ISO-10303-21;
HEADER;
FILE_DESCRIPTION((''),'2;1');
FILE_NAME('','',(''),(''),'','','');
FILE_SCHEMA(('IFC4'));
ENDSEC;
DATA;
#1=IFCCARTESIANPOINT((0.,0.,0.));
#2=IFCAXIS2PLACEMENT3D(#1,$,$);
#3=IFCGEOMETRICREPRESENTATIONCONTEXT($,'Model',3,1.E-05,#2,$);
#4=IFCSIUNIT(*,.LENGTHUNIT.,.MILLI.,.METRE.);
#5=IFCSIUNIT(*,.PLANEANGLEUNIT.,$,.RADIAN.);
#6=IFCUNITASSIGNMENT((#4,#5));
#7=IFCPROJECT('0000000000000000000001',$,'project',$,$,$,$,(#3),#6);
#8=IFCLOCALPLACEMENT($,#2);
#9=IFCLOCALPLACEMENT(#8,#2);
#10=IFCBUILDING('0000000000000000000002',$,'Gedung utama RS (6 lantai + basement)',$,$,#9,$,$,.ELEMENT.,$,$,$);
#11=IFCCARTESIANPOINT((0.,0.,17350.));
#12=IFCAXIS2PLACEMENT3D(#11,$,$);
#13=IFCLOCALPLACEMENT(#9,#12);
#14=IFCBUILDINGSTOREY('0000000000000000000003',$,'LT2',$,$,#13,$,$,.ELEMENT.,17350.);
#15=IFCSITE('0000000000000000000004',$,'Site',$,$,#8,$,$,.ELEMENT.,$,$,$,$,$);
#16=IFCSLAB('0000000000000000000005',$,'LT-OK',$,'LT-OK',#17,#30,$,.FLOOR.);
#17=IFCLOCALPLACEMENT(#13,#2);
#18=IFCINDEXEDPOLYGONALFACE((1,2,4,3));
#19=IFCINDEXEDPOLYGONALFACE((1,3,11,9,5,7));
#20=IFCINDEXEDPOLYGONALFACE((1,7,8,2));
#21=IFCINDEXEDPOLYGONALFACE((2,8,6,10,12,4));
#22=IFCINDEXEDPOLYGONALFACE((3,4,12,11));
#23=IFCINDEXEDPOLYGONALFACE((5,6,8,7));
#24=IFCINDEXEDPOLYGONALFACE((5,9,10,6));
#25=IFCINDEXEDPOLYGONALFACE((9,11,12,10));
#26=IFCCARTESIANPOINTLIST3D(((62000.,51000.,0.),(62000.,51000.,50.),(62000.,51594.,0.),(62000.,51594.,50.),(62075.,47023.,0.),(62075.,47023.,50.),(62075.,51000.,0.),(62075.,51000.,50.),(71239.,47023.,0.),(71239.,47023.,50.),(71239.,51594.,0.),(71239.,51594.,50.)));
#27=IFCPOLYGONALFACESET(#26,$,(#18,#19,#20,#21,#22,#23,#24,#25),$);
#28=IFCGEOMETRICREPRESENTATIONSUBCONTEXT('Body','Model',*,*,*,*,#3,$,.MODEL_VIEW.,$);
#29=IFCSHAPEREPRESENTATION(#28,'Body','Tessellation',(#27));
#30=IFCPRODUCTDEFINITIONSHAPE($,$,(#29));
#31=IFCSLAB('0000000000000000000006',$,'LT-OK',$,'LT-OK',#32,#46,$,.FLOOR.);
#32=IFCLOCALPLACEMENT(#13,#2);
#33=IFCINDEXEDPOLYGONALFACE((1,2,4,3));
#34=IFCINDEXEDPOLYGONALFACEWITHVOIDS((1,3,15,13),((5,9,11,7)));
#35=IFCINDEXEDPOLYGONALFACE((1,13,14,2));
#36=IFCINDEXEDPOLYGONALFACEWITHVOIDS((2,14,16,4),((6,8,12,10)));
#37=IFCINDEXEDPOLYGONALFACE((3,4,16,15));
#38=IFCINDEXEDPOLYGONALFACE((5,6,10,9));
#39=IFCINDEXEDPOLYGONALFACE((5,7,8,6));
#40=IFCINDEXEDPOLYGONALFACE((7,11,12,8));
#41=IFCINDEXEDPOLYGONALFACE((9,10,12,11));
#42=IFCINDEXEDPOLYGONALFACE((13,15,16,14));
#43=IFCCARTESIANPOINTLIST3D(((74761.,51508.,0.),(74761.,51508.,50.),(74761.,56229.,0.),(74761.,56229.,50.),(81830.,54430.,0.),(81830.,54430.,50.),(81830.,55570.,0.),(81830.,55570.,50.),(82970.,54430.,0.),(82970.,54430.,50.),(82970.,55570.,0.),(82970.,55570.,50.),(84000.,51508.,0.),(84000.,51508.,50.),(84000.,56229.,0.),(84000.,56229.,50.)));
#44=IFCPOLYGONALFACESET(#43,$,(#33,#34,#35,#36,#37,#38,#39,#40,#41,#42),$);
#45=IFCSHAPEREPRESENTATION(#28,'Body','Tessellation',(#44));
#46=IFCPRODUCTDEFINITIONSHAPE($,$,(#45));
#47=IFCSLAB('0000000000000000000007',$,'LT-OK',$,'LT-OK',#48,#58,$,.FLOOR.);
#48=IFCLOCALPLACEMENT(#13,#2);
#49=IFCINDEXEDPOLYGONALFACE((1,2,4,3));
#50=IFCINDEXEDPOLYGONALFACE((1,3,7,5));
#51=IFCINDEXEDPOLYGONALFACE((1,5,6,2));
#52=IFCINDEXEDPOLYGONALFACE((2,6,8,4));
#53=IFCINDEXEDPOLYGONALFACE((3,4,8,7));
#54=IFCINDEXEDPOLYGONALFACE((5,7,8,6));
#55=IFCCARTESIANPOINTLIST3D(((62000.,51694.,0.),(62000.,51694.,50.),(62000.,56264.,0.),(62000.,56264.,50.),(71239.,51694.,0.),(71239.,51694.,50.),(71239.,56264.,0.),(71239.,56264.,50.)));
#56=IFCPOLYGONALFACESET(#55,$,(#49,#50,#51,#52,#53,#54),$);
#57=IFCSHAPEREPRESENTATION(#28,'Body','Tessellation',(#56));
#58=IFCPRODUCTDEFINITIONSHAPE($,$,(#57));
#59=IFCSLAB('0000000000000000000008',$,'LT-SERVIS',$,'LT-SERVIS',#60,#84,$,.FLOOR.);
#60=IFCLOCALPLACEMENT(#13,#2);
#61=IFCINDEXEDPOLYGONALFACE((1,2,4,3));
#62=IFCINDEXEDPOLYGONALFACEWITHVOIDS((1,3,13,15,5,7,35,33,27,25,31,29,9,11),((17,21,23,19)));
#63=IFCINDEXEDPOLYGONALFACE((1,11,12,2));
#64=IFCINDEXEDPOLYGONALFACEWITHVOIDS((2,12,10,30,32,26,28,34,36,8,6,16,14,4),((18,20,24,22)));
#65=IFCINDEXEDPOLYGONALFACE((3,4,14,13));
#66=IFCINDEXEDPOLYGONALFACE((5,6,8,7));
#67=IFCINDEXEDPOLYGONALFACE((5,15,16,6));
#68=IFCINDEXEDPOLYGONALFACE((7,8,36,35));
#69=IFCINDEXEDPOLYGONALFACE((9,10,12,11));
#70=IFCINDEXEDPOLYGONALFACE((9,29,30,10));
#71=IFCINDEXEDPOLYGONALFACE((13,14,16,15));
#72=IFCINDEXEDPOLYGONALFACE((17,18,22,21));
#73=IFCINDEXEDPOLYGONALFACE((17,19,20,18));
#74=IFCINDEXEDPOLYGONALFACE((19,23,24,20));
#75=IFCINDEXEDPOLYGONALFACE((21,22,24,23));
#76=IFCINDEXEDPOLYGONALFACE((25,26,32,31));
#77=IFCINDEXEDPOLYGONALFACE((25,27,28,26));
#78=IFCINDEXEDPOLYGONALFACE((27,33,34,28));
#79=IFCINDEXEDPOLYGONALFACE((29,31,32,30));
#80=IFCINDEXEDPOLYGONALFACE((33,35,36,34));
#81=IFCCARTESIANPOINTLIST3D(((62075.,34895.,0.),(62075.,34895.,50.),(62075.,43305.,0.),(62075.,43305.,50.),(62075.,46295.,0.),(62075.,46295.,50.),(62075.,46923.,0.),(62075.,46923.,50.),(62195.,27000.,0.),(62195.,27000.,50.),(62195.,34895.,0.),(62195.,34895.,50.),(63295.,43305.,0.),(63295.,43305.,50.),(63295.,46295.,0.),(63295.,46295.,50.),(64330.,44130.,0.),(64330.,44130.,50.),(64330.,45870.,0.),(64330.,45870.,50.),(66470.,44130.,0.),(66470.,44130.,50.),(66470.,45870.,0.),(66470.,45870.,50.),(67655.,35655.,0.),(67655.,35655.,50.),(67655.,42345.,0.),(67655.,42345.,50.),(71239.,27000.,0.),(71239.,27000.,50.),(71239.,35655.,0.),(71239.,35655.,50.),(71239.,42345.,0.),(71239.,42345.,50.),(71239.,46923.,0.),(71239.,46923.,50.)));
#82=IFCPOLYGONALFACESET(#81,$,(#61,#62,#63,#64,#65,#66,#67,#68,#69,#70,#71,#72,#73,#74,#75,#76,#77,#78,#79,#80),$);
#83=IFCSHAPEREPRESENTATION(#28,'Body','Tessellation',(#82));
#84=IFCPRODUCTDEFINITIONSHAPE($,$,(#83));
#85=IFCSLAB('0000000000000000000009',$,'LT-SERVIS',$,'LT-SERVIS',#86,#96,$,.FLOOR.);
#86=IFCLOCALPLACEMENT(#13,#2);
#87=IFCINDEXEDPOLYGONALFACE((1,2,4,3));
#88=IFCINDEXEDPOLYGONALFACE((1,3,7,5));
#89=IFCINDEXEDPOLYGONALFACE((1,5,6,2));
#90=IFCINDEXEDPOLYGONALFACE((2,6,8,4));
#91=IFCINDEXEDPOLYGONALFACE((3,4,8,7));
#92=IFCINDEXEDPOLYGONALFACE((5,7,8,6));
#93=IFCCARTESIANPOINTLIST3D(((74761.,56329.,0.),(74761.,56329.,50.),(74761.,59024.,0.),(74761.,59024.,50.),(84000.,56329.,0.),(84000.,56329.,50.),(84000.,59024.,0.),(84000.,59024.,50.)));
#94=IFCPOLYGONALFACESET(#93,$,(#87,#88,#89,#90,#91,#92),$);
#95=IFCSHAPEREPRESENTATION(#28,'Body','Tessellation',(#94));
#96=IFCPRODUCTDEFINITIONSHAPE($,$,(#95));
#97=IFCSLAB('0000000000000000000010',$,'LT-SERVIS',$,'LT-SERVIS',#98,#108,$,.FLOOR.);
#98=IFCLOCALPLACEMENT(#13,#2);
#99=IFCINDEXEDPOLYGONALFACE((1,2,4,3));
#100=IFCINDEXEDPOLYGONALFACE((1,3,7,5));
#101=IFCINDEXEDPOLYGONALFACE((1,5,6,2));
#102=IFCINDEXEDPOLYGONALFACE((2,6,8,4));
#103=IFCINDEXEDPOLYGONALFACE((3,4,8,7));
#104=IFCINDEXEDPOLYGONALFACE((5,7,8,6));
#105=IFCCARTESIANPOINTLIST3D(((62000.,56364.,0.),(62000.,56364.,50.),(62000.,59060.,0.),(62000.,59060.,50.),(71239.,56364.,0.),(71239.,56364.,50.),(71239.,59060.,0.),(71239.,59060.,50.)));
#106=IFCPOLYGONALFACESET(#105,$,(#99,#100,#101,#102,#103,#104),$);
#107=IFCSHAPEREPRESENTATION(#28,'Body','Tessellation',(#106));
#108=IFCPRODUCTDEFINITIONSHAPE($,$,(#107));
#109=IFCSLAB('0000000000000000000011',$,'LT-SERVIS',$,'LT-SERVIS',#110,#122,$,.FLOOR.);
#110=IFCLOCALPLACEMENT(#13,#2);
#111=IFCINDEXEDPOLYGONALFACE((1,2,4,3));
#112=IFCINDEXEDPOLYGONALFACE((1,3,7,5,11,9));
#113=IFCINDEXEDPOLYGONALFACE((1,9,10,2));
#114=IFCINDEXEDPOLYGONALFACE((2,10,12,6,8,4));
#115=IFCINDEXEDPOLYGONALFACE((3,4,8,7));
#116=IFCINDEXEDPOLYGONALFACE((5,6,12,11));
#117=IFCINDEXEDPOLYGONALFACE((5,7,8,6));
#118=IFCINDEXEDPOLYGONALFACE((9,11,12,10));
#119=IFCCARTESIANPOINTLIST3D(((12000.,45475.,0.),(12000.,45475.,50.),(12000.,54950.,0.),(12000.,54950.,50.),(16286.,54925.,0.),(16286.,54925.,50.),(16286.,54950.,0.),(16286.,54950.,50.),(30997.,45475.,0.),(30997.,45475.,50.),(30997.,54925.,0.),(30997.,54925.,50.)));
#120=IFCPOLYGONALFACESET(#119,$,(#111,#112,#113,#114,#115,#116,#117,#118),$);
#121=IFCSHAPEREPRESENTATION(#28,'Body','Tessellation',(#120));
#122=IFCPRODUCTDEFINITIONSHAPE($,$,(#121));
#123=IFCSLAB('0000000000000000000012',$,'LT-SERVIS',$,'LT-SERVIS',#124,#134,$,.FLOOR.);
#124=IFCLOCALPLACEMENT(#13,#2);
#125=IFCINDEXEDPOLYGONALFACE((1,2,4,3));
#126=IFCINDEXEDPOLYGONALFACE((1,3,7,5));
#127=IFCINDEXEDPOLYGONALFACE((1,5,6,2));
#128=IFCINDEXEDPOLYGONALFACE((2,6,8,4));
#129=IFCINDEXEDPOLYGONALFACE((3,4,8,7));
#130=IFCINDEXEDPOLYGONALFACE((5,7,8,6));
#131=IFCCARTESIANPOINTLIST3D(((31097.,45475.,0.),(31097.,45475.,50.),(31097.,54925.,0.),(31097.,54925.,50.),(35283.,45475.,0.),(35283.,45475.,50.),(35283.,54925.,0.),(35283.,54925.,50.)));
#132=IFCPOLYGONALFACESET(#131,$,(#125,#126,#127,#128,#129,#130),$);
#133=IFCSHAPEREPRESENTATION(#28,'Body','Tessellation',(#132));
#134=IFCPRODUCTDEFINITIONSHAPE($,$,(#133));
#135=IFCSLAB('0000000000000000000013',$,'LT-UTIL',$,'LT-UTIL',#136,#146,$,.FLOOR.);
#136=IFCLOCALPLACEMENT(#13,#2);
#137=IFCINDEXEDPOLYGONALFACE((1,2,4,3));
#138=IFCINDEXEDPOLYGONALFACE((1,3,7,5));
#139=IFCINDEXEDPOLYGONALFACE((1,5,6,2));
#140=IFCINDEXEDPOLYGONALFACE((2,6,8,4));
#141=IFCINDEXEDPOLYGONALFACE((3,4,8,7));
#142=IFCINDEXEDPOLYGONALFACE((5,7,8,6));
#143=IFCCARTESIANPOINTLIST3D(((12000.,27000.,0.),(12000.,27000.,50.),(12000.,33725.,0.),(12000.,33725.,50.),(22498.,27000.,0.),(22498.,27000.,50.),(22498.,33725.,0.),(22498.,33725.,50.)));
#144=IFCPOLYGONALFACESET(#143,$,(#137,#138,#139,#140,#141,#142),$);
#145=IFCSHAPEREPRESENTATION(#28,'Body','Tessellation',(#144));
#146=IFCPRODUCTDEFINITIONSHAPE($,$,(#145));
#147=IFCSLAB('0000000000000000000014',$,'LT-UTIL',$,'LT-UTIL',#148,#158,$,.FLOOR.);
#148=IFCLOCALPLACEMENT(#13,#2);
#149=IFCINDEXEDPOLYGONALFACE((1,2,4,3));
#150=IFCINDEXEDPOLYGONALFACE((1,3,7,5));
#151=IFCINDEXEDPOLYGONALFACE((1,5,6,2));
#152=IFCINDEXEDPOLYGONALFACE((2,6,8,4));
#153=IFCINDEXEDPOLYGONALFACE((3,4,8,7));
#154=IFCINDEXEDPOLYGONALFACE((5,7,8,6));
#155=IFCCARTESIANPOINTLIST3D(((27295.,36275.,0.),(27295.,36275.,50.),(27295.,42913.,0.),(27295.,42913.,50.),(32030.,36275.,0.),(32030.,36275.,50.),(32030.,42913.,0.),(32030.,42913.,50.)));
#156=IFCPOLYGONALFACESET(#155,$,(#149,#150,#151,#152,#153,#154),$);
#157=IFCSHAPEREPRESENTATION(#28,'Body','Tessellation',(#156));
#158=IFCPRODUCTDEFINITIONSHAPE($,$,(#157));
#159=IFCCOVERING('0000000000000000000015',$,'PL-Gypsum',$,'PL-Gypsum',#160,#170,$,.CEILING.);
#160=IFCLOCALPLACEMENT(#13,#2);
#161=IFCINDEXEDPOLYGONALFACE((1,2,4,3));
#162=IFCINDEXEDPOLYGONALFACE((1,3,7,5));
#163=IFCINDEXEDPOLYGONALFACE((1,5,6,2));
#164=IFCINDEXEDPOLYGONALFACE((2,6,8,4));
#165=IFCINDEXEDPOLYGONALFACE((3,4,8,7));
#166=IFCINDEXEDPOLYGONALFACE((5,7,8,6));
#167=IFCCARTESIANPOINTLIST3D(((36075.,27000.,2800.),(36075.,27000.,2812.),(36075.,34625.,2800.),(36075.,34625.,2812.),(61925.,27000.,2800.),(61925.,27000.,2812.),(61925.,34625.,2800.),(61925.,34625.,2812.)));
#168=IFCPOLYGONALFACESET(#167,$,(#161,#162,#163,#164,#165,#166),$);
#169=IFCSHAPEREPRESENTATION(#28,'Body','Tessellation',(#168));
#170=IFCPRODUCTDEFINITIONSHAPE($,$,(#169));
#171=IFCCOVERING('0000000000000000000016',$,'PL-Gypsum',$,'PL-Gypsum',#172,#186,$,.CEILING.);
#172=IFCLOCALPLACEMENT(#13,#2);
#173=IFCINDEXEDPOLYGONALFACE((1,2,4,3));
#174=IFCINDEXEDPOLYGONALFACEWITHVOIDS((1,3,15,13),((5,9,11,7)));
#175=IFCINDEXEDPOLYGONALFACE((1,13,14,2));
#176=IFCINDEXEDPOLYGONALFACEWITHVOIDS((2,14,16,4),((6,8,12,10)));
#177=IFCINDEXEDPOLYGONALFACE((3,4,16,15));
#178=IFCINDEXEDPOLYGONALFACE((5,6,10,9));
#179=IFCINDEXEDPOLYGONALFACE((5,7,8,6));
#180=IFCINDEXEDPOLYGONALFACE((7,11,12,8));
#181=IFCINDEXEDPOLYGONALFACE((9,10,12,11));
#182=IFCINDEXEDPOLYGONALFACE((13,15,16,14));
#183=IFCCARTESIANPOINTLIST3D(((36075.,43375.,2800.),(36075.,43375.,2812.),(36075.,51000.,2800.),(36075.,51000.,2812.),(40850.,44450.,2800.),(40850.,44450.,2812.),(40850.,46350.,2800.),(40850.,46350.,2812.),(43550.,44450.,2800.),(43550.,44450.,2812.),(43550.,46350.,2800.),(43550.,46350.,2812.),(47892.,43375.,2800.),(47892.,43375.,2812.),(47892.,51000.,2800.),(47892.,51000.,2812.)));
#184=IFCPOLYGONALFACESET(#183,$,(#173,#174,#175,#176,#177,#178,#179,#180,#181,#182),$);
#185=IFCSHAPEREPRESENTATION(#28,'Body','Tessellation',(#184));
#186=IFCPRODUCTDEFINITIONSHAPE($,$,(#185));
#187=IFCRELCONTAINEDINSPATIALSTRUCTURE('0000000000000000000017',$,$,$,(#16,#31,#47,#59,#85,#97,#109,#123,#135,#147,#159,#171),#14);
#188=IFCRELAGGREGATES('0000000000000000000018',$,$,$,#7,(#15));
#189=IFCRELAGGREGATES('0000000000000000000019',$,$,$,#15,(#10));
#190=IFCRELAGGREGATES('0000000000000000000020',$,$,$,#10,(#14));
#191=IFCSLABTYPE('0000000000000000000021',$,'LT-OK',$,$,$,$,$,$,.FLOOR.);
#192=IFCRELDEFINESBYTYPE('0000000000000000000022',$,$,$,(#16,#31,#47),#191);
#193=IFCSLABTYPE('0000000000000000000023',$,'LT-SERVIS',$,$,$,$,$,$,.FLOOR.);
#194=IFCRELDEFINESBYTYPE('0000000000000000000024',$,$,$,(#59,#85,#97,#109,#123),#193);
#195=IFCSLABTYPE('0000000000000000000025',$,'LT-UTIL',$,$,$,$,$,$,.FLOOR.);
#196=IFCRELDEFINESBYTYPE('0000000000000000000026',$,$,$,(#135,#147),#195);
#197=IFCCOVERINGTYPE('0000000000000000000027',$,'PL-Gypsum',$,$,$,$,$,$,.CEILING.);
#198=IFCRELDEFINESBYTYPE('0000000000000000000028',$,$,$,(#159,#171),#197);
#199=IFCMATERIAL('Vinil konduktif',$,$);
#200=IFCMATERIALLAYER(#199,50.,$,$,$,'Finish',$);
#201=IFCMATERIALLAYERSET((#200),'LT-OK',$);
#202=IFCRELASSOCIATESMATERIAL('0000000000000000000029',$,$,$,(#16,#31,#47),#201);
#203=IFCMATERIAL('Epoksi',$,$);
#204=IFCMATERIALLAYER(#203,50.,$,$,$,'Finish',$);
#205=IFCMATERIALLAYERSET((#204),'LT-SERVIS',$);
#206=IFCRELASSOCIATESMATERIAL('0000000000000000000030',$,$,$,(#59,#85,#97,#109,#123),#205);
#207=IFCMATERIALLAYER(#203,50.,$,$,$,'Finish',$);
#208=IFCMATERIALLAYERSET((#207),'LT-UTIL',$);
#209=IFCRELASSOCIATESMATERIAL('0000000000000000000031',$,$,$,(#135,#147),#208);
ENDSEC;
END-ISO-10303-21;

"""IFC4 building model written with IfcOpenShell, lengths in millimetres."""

from ifc_helpers import new_model, si_unit, frame, origin, place, context, subcontext, project, spatial, polyline, outline, extrude, material, layer, layer_set, layer_usage, type_object, element, save


model = new_model("IFC4")

# Units and contexts
model_context = context("Model", 3, precision=1e-05, world=origin())
body_context = subcontext(model_context, "Body", "Model", "MODEL_VIEW")
ifc_project = project(units=[si_unit("LENGTHUNIT", "METRE", prefix="MILLI"), si_unit("PLANEANGLEUNIT", "RADIAN")], contexts=[model_context])

# Site, building, storey
site_placement = place(None, origin())
site = spatial("IfcSite", under=ifc_project, at=site_placement, Name="Site", CompositionType="ELEMENT")
building_placement = place(site_placement, origin())
building = spatial("IfcBuilding", under=site, at=building_placement, Name="Gedung utama RS (6 lantai + basement)", CompositionType="ELEMENT")
storey_placement = place(building_placement, frame((0.0, 0.0, 17350.0)))
storey = spatial("IfcBuildingStorey", under=building, at=storey_placement, Name="LT2", CompositionType="ELEMENT", Elevation=17350.0)

# Slabs
ifc_material_1 = material(Name="Vinil konduktif")
ifc_layer_1 = layer(ifc_material_1, 50.0, Category="Finish")
ifc_layer_set_1 = layer_set([ifc_layer_1], Name="LT-OK")
ifc_layer_usage_1 = layer_usage(ifc_layer_set_1, "AXIS3", "NEGATIVE", 50.0)
slab_type_1 = type_object("IfcSlabType", Name="LT-OK", PredefinedType="FLOOR")
slab_1_placement = place(storey_placement, origin())
element("IfcSlab", 1, at=slab_1_placement, inside=storey, type_object=slab_type_1, material=ifc_layer_usage_1, Name="LT-OK", ObjectType="LT-OK", PredefinedType="FLOOR", context=body_context, shape_type="SweptSolid", body=[
    extrude(outline(polyline([(62075.0, 47023.0), (71239.0, 47023.0), (71239.0, 51594.0), (62000.0, 51594.0), (62000.0, 51000.0), (62075.0, 51000.0), (62075.0, 47023.0)])), origin(), (0.0, 0.0, 1.0), 50.0),
])
slab_2_placement = place(storey_placement, origin())
element("IfcSlab", 2, at=slab_2_placement, inside=storey, type_object=slab_type_1, material=ifc_layer_usage_1, Name="LT-OK", ObjectType="LT-OK", PredefinedType="FLOOR", context=body_context, shape_type="SweptSolid", body=[
    extrude(outline(polyline([(74761.0, 51508.0), (84000.0, 51508.0), (84000.0, 56229.0), (74761.0, 56229.0), (74761.0, 51508.0)]), holes=[polyline([(81830.0, 54430.0), (81830.0, 55570.0), (82970.0, 55570.0), (82970.0, 54430.0), (81830.0, 54430.0)])]), origin(), (0.0, 0.0, 1.0), 50.0),
])
slab_3_placement = place(storey_placement, origin())
element("IfcSlab", 3, at=slab_3_placement, inside=storey, type_object=slab_type_1, material=ifc_layer_usage_1, Name="LT-OK", ObjectType="LT-OK", PredefinedType="FLOOR", context=body_context, shape_type="SweptSolid", body=[
    extrude(outline(polyline([(62000.0, 51694.0), (71239.0, 51694.0), (71239.0, 56264.0), (62000.0, 56264.0), (62000.0, 51694.0)])), origin(), (0.0, 0.0, 1.0), 50.0),
])
ifc_material_2 = material(Name="Epoksi")
ifc_layer_2 = layer(ifc_material_2, 50.0, Category="Finish")
ifc_layer_set_2 = layer_set([ifc_layer_2], Name="LT-SERVIS")
ifc_layer_usage_2 = layer_usage(ifc_layer_set_2, "AXIS3", "NEGATIVE", 50.0)
slab_type_2 = type_object("IfcSlabType", Name="LT-SERVIS", PredefinedType="FLOOR")
slab_4_placement = place(storey_placement, origin())
element("IfcSlab", 4, at=slab_4_placement, inside=storey, type_object=slab_type_2, material=ifc_layer_usage_2, Name="LT-SERVIS", ObjectType="LT-SERVIS", PredefinedType="FLOOR", context=body_context, shape_type="SweptSolid", body=[
    extrude(outline(polyline([(62195.0, 27000.0), (71239.0, 27000.0), (71239.0, 35655.0), (67655.0, 35655.0), (67655.0, 42345.0), (71239.0, 42345.0), (71239.0, 46923.0), (62075.0, 46923.0), (62075.0, 46295.0), (63295.0, 46295.0), (63295.0, 43305.0), (62075.0, 43305.0), (62075.0, 34895.0), (62195.0, 34895.0), (62195.0, 27000.0)]), holes=[polyline([(64330.0, 44130.0), (64330.0, 45870.0), (66470.0, 45870.0), (66470.0, 44130.0), (64330.0, 44130.0)])]), origin(), (0.0, 0.0, 1.0), 50.0),
])
slab_5_placement = place(storey_placement, origin())
element("IfcSlab", 5, at=slab_5_placement, inside=storey, type_object=slab_type_2, material=ifc_layer_usage_2, Name="LT-SERVIS", ObjectType="LT-SERVIS", PredefinedType="FLOOR", context=body_context, shape_type="SweptSolid", body=[
    extrude(outline(polyline([(74761.0, 56329.0), (84000.0, 56329.0), (84000.0, 59024.0), (74761.0, 59024.0), (74761.0, 56329.0)])), origin(), (0.0, 0.0, 1.0), 50.0),
])
slab_6_placement = place(storey_placement, origin())
element("IfcSlab", 6, at=slab_6_placement, inside=storey, type_object=slab_type_2, material=ifc_layer_usage_2, Name="LT-SERVIS", ObjectType="LT-SERVIS", PredefinedType="FLOOR", context=body_context, shape_type="SweptSolid", body=[
    extrude(outline(polyline([(62000.0, 56364.0), (71239.0, 56364.0), (71239.0, 59060.0), (62000.0, 59060.0), (62000.0, 56364.0)])), origin(), (0.0, 0.0, 1.0), 50.0),
])
slab_7_placement = place(storey_placement, origin())
element("IfcSlab", 7, at=slab_7_placement, inside=storey, type_object=slab_type_2, material=ifc_layer_usage_2, Name="LT-SERVIS", ObjectType="LT-SERVIS", PredefinedType="FLOOR", context=body_context, shape_type="SweptSolid", body=[
    extrude(outline(polyline([(12000.0, 45475.0), (30997.0, 45475.0), (30997.0, 54925.0), (16286.0, 54925.0), (16286.0, 54950.0), (12000.0, 54950.0), (12000.0, 45475.0)])), origin(), (0.0, 0.0, 1.0), 50.0),
])
slab_8_placement = place(storey_placement, origin())
element("IfcSlab", 8, at=slab_8_placement, inside=storey, type_object=slab_type_2, material=ifc_layer_usage_2, Name="LT-SERVIS", ObjectType="LT-SERVIS", PredefinedType="FLOOR", context=body_context, shape_type="SweptSolid", body=[
    extrude(outline(polyline([(31097.0, 45475.0), (35283.0, 45475.0), (35283.0, 54925.0), (31097.0, 54925.0), (31097.0, 45475.0)])), origin(), (0.0, 0.0, 1.0), 50.0),
])
ifc_layer_3 = layer(ifc_material_2, 50.0, Category="Finish")
ifc_layer_set_3 = layer_set([ifc_layer_3], Name="LT-UTIL")
ifc_layer_usage_3 = layer_usage(ifc_layer_set_3, "AXIS3", "NEGATIVE", 50.0)
slab_type_3 = type_object("IfcSlabType", Name="LT-UTIL", PredefinedType="FLOOR")
slab_9_placement = place(storey_placement, origin())
element("IfcSlab", 9, at=slab_9_placement, inside=storey, type_object=slab_type_3, material=ifc_layer_usage_3, Name="LT-UTIL", ObjectType="LT-UTIL", PredefinedType="FLOOR", context=body_context, shape_type="SweptSolid", body=[
    extrude(outline(polyline([(12000.0, 27000.0), (22498.0, 27000.0), (22498.0, 33725.0), (12000.0, 33725.0), (12000.0, 27000.0)])), origin(), (0.0, 0.0, 1.0), 50.0),
])
slab_10_placement = place(storey_placement, origin())
element("IfcSlab", 10, at=slab_10_placement, inside=storey, type_object=slab_type_3, material=ifc_layer_usage_3, Name="LT-UTIL", ObjectType="LT-UTIL", PredefinedType="FLOOR", context=body_context, shape_type="SweptSolid", body=[
    extrude(outline(polyline([(27295.0, 36275.0), (32030.0, 36275.0), (32030.0, 42913.0), (27295.0, 42913.0), (27295.0, 36275.0)])), origin(), (0.0, 0.0, 1.0), 50.0),
])

# Coverings
covering_type = type_object("IfcCoveringType", Name="PL-Gypsum", PredefinedType="CEILING")
covering_1_placement = place(storey_placement, origin())
element("IfcCovering", 11, at=covering_1_placement, inside=storey, type_object=covering_type, Name="PL-Gypsum", ObjectType="PL-Gypsum", PredefinedType="CEILING", context=body_context, shape_type="SweptSolid", body=[
    extrude(outline(polyline([(36075.0, 27000.0), (61925.0, 27000.0), (61925.0, 34625.0), (36075.0, 34625.0), (36075.0, 27000.0)])), frame((0.0, 0.0, 2800.0)), (0.0, 0.0, 1.0), 12.0),
])
covering_2_placement = place(storey_placement, origin())
element("IfcCovering", 12, at=covering_2_placement, inside=storey, type_object=covering_type, Name="PL-Gypsum", ObjectType="PL-Gypsum", PredefinedType="CEILING", context=body_context, shape_type="SweptSolid", body=[
    extrude(outline(polyline([(36075.0, 43375.0), (47892.0, 43375.0), (47892.0, 51000.0), (36075.0, 51000.0), (36075.0, 43375.0)]), holes=[polyline([(40850.0, 44450.0), (40850.0, 46350.0), (43550.0, 46350.0), (43550.0, 44450.0), (40850.0, 44450.0)])]), frame((0.0, 0.0, 2800.0)), (0.0, 0.0, 1.0), 12.0),
])

save(model, "model.ifc")
